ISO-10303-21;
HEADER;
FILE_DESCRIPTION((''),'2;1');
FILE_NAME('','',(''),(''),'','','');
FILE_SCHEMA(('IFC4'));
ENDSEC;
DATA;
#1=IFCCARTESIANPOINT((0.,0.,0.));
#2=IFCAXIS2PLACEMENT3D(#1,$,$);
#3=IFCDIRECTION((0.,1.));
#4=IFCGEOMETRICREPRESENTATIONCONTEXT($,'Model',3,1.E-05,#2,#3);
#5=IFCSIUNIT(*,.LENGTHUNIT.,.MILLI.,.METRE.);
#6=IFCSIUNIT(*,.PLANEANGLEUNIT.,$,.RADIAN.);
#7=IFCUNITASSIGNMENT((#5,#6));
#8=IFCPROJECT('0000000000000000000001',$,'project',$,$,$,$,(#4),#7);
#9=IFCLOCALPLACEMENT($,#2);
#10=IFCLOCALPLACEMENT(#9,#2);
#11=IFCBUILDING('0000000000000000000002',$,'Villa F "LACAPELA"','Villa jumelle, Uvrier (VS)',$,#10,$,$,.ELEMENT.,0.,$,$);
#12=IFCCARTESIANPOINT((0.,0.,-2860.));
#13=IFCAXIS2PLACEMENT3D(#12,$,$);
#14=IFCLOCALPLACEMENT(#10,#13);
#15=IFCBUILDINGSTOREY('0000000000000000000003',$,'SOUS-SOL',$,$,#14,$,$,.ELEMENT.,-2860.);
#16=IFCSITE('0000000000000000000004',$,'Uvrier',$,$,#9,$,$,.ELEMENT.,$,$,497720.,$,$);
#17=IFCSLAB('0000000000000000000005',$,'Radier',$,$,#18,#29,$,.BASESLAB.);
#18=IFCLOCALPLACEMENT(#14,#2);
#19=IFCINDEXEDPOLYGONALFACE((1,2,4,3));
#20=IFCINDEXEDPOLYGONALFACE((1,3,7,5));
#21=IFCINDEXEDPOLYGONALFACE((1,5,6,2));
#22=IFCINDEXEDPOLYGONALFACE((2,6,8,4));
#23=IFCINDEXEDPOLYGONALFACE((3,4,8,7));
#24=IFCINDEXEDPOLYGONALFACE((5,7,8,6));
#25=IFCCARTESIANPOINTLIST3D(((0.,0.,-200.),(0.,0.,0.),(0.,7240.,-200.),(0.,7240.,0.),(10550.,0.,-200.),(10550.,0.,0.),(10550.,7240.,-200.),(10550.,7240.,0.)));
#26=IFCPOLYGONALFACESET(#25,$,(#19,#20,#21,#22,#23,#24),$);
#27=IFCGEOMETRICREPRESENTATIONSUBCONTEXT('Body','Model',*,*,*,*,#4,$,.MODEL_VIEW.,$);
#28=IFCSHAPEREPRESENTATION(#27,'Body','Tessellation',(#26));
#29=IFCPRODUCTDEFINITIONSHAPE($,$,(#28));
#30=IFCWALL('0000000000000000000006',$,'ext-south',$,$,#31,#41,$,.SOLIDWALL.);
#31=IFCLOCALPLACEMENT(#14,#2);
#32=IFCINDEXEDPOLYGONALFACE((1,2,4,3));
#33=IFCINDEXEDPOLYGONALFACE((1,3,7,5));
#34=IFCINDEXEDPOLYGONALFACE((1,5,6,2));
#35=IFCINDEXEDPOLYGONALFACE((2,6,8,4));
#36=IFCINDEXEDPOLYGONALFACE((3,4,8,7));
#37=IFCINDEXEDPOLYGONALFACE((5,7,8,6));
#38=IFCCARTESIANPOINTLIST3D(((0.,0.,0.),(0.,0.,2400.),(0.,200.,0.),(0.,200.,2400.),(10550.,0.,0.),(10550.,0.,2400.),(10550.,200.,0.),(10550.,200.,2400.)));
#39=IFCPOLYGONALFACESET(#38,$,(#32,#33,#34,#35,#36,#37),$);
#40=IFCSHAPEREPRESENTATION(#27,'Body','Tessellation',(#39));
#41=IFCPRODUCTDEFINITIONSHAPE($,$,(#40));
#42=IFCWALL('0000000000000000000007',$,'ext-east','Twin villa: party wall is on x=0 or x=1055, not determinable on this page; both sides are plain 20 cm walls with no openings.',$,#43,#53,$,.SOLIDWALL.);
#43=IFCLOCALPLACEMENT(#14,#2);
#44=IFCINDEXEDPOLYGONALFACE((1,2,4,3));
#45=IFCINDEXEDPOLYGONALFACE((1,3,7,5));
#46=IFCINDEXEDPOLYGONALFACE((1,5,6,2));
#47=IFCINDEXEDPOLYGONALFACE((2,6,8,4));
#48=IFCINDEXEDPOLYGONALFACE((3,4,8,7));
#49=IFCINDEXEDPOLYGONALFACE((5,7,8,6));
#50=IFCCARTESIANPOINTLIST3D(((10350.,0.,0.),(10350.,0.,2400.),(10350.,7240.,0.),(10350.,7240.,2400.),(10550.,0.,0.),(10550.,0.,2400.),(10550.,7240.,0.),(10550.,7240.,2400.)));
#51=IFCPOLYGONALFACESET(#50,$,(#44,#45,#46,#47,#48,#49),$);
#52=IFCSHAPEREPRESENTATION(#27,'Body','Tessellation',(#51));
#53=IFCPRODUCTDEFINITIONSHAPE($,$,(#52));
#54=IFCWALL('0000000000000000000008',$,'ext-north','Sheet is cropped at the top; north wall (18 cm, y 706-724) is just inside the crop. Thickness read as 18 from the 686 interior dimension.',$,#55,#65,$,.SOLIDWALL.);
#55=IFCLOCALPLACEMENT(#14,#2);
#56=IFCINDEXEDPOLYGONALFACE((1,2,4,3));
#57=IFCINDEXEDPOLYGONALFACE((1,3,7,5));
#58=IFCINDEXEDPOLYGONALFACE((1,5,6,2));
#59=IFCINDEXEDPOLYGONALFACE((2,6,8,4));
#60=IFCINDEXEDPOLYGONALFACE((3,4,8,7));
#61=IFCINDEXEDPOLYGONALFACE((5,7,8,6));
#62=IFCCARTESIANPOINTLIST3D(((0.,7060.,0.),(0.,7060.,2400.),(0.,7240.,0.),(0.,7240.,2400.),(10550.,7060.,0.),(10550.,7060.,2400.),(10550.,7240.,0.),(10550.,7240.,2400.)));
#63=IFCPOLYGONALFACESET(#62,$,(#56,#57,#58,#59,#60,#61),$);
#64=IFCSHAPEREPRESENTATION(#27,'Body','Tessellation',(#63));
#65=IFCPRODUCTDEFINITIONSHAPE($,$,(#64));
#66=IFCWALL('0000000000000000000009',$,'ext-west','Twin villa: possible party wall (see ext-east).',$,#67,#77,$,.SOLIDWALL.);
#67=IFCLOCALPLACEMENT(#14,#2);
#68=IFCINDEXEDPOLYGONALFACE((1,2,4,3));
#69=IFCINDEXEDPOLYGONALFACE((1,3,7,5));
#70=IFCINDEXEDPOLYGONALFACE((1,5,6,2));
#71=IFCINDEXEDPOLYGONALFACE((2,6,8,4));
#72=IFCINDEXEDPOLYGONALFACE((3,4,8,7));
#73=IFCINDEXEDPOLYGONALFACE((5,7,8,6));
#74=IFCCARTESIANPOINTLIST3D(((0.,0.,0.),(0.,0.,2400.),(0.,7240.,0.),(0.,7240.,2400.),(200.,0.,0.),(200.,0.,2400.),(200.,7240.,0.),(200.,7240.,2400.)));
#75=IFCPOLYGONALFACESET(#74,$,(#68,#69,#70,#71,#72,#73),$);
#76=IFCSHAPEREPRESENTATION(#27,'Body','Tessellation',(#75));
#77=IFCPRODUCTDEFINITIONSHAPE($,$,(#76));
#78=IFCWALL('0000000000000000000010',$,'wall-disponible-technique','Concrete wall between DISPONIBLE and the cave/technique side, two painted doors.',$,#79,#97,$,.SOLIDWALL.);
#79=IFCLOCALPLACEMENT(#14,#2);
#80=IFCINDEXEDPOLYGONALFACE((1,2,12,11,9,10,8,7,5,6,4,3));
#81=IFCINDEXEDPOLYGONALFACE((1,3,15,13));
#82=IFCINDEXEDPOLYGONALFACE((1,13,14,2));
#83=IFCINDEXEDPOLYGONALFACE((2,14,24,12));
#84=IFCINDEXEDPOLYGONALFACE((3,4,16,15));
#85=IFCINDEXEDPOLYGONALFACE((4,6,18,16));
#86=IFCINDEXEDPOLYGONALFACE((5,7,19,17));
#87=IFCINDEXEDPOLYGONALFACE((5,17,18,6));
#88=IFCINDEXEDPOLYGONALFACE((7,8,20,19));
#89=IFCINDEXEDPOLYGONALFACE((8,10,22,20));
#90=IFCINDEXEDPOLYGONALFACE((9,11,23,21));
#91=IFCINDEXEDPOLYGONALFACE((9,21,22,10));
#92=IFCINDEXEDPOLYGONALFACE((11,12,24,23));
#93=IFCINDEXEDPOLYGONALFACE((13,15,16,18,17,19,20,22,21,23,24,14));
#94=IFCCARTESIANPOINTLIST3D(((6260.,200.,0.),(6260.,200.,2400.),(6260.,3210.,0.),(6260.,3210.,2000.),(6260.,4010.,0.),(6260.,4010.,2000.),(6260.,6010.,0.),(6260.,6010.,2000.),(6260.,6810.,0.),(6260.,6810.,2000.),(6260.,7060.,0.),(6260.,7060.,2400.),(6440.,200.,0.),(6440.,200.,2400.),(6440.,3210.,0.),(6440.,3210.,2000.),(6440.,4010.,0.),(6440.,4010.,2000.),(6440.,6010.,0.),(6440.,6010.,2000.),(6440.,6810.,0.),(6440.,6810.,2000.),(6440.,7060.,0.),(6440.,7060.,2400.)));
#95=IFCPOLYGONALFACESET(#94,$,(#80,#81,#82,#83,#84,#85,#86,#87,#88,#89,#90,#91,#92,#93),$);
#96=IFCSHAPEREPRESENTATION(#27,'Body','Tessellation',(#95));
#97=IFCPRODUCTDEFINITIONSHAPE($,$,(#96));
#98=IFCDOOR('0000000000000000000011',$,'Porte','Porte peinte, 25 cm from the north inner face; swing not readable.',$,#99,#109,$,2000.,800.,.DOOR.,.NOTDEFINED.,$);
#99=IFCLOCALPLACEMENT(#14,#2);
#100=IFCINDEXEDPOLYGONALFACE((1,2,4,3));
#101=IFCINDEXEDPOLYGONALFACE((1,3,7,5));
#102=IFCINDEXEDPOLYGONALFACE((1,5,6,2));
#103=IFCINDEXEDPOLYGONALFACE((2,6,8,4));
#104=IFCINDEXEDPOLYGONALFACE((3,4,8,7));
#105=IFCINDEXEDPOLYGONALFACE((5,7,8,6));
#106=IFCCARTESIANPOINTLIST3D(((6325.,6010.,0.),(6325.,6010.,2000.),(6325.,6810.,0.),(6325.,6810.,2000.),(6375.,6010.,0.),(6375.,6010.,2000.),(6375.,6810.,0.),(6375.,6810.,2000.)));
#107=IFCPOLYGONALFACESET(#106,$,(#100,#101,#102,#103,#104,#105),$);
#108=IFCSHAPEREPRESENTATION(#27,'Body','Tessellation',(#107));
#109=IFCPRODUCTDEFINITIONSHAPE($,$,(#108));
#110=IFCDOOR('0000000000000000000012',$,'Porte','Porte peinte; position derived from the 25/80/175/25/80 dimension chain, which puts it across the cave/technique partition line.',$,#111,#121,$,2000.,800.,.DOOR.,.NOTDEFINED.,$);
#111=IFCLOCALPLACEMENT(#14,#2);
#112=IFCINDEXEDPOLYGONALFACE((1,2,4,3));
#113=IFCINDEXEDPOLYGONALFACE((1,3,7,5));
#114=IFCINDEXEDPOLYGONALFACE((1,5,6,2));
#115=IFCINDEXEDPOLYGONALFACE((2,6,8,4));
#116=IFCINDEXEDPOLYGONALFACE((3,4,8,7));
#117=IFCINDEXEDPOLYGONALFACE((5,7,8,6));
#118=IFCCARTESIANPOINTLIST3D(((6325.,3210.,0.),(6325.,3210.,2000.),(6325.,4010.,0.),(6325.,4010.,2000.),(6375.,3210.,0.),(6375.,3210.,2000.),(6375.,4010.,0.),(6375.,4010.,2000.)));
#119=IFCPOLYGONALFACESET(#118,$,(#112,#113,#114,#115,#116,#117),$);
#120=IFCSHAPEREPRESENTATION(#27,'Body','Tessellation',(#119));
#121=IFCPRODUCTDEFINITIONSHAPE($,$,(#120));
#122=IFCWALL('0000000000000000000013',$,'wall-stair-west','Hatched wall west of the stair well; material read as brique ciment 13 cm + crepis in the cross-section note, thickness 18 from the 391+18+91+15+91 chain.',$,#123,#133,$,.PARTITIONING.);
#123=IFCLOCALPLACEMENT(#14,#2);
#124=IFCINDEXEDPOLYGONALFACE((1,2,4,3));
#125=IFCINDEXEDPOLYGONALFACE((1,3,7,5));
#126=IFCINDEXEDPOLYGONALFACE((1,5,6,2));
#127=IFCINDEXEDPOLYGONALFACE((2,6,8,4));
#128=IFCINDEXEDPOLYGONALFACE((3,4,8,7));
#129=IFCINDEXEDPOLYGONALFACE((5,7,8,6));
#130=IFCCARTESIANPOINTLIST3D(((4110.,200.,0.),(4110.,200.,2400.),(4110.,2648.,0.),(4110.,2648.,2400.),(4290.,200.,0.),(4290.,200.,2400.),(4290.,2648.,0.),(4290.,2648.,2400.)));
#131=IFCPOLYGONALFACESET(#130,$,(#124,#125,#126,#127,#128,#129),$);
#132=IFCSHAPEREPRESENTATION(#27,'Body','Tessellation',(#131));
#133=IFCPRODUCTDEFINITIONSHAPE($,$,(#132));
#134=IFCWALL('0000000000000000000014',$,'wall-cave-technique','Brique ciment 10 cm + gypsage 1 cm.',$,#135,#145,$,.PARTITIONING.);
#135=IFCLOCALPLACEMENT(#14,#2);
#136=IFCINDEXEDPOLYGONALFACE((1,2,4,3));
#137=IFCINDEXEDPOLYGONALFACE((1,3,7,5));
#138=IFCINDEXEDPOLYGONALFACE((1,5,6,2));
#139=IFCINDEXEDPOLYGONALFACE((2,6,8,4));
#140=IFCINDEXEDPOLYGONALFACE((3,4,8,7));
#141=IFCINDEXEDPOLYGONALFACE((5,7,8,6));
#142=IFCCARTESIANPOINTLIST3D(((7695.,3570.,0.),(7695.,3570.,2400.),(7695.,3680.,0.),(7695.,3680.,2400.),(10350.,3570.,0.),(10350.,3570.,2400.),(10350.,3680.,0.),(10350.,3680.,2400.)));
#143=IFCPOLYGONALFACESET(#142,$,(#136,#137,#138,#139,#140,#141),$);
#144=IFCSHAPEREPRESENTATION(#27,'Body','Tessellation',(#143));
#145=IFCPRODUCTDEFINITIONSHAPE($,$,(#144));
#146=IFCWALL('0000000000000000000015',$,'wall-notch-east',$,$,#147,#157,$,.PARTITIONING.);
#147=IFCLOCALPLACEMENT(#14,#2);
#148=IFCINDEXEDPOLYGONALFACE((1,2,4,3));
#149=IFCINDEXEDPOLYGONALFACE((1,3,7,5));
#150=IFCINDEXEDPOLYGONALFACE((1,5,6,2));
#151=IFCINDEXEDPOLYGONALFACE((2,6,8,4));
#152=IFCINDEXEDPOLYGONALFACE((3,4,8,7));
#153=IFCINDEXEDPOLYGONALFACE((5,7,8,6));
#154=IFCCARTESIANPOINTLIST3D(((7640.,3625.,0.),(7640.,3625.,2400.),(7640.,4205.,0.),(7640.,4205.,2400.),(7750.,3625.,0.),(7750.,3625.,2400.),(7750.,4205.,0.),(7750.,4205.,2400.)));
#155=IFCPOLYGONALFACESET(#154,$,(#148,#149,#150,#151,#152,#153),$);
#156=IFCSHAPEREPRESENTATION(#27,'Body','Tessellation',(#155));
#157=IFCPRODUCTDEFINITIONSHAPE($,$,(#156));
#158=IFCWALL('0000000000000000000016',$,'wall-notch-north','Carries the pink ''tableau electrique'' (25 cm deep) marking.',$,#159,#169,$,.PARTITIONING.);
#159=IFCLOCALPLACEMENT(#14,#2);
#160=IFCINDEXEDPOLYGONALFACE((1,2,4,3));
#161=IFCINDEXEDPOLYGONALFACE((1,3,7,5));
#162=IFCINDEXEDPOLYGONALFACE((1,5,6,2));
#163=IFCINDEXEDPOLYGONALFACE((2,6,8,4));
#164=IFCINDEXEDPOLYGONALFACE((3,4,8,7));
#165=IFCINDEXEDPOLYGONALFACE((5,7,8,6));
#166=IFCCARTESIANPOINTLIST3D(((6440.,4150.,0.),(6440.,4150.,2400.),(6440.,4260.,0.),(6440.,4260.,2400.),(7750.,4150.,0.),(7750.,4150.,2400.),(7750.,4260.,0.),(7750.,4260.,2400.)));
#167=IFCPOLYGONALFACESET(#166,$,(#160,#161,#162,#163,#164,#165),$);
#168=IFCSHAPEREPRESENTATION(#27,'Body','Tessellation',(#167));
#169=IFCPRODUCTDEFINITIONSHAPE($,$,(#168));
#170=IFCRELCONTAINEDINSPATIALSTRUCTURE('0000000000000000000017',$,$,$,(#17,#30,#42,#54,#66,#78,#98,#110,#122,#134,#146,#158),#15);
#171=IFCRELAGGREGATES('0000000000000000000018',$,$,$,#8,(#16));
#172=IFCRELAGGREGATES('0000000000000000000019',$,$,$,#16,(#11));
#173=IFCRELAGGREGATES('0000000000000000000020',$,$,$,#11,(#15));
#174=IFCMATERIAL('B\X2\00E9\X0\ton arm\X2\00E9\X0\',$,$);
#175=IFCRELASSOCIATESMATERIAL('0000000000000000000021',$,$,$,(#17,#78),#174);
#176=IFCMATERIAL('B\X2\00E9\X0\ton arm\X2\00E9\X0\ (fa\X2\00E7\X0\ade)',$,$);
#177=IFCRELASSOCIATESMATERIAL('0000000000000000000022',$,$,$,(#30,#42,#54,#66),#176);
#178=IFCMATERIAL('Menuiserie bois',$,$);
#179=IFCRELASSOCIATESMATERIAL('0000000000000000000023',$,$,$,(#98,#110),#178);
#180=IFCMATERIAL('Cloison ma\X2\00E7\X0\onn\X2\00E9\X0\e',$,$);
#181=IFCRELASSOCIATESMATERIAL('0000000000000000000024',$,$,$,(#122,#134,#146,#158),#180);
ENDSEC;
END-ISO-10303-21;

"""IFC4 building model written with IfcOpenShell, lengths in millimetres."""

from ifc_helpers import new_model, si_unit, direction, frame, frame_2d, origin, place, context, subcontext, project, spatial, polyline, rectangle, outline, extrude, material, element, fill, save


model = new_model("IFC4")

# Units and contexts
model_context = context("Model", 3, precision=1e-05, world=origin(), true_north=direction((0.0, 1.0)))
body_context = subcontext(model_context, "Body", "Model", "MODEL_VIEW")
ifc_project = project(units=[si_unit("LENGTHUNIT", "METRE", prefix="MILLI"), si_unit("PLANEANGLEUNIT", "RADIAN")], contexts=[model_context])

# Site, building, storey
site_placement = place(None, origin())
site = spatial("IfcSite", under=ifc_project, at=site_placement, Name="Uvrier", CompositionType="ELEMENT", RefElevation=497720.0)
building_placement = place(site_placement, origin())
building = spatial("IfcBuilding", under=site, at=building_placement, Name="Villa F \"LACAPELA\"", Description="Villa jumelle, Uvrier (VS)", CompositionType="ELEMENT", ElevationOfRefHeight=0.0)
storey_placement = place(building_placement, frame((0.0, 0.0, -2860.0)))
storey = spatial("IfcBuildingStorey", under=building, at=storey_placement, Name="SOUS-SOL", CompositionType="ELEMENT", Elevation=-2860.0)

# Slab
ifc_material_1 = material(Name="Béton armé")
slab_placement = place(storey_placement, origin())
element("IfcSlab", 1, at=slab_placement, inside=storey, material=ifc_material_1, Name="Radier", PredefinedType="BASESLAB", context=body_context, shape_type="SweptSolid", body=[
    extrude(outline(polyline([(0.0, 0.0), (10550.0, 0.0), (10550.0, 7240.0), (0.0, 7240.0), (0.0, 0.0)])), frame((0.0, 0.0, -200.0)), (0.0, 0.0, 1.0), 200.0),
])

# Walls
ifc_material_2 = material(Name="Béton armé (façade)")
wall_1_placement = place(storey_placement, frame((0.0, 100.0, 0.0), z_axis=(0.0, 0.0, 1.0), x_axis=(1.0, 0.0, 0.0)))
element("IfcWall", 2, at=wall_1_placement, inside=storey, material=ifc_material_2, Name="ext-south", PredefinedType="SOLIDWALL", context=body_context, shape_type="SweptSolid", body=[
    extrude(rectangle(XDim=10550.0, YDim=200.0, at=frame_2d((5275.0, 0.0))), origin(), (0.0, 0.0, 1.0), 2400.0),
])
wall_2_placement = place(storey_placement, frame((10450.0, 0.0, 0.0), z_axis=(0.0, 0.0, 1.0), x_axis=(0.0, 1.0, 0.0)))
element("IfcWall", 3, at=wall_2_placement, inside=storey, material=ifc_material_2, Name="ext-east", Description="Twin villa: party wall is on x=0 or x=1055, not determinable on this page; both sides are plain 20 cm walls with no openings.", PredefinedType="SOLIDWALL", context=body_context, shape_type="SweptSolid", body=[
    extrude(rectangle(XDim=7240.0, YDim=200.0, at=frame_2d((3620.0, 0.0))), origin(), (0.0, 0.0, 1.0), 2400.0),
])
wall_3_placement = place(storey_placement, frame((10550.0, 7150.0, 0.0), z_axis=(0.0, 0.0, 1.0), x_axis=(-1.0, 0.0, 0.0)))
element("IfcWall", 4, at=wall_3_placement, inside=storey, material=ifc_material_2, Name="ext-north", Description="Sheet is cropped at the top; north wall (18 cm, y 706-724) is just inside the crop. Thickness read as 18 from the 686 interior dimension.", PredefinedType="SOLIDWALL", context=body_context, shape_type="SweptSolid", body=[
    extrude(rectangle(XDim=10550.0, YDim=180.0, at=frame_2d((5275.0, 0.0))), origin(), (0.0, 0.0, 1.0), 2400.0),
])
wall_4_placement = place(storey_placement, frame((100.0, 7240.0, 0.0), z_axis=(0.0, 0.0, 1.0), x_axis=(0.0, -1.0, 0.0)))
element("IfcWall", 5, at=wall_4_placement, inside=storey, material=ifc_material_2, Name="ext-west", Description="Twin villa: possible party wall (see ext-east).", PredefinedType="SOLIDWALL", context=body_context, shape_type="SweptSolid", body=[
    extrude(rectangle(XDim=7240.0, YDim=200.0, at=frame_2d((3620.0, 0.0))), origin(), (0.0, 0.0, 1.0), 2400.0),
])

# Wall, openings, doors
wall_5_placement = place(storey_placement, frame((6350.0, 200.0, 0.0), z_axis=(0.0, 0.0, 1.0), x_axis=(0.0, 1.0, 0.0)))
wall_5 = element("IfcWall", 6, at=wall_5_placement, inside=storey, material=ifc_material_1, Name="wall-disponible-technique", Description="Concrete wall between DISPONIBLE and the cave/technique side, two painted doors.", PredefinedType="SOLIDWALL", context=body_context, shape_type="SweptSolid", body=[
    extrude(rectangle(XDim=6860.0, YDim=180.0, at=frame_2d((3430.0, 0.0))), origin(), (0.0, 0.0, 1.0), 2400.0),
])
opening_1_placement = place(wall_5_placement, frame((5810.0, 0.0, 0.0)))
opening_1 = element("IfcOpeningElement", 7, at=opening_1_placement, cuts=wall_5, PredefinedType="OPENING", context=body_context, shape_type="SweptSolid", body=[
    extrude(rectangle(XDim=800.0, YDim=380.0, at=frame_2d((400.0, 0.0))), origin(), (0.0, 0.0, 1.0), 2000.0),
])
opening_2_placement = place(wall_5_placement, frame((3010.0, 0.0, 0.0)))
opening_2 = element("IfcOpeningElement", 8, at=opening_2_placement, cuts=wall_5, PredefinedType="OPENING", context=body_context, shape_type="SweptSolid", body=[
    extrude(rectangle(XDim=800.0, YDim=380.0, at=frame_2d((400.0, 0.0))), origin(), (0.0, 0.0, 1.0), 2000.0),
])
ifc_material_3 = material(Name="Menuiserie bois")
door_1_placement = place(opening_1_placement, origin())
door_1 = element("IfcDoor", 9, at=door_1_placement, inside=storey, material=ifc_material_3, Name="Porte", Description="Porte peinte, 25 cm from the north inner face; swing not readable.", OperationType="NOTDEFINED", OverallHeight=2000.0, OverallWidth=800.0, PredefinedType="DOOR", context=body_context, shape_type="SweptSolid", body=[
    extrude(rectangle(XDim=800.0, YDim=50.0, at=frame_2d((400.0, 0.0))), origin(), (0.0, 0.0, 1.0), 2000.0),
])
fill(opening_1, door_1)
door_2_placement = place(opening_2_placement, origin())
door_2 = element("IfcDoor", 10, at=door_2_placement, inside=storey, material=ifc_material_3, Name="Porte", Description="Porte peinte; position derived from the 25/80/175/25/80 dimension chain, which puts it across the cave/technique partition line.", OperationType="NOTDEFINED", OverallHeight=2000.0, OverallWidth=800.0, PredefinedType="DOOR", context=body_context, shape_type="SweptSolid", body=[
    extrude(rectangle(XDim=800.0, YDim=50.0, at=frame_2d((400.0, 0.0))), origin(), (0.0, 0.0, 1.0), 2000.0),
])
fill(opening_2, door_2)

# Walls
ifc_material_4 = material(Name="Cloison maçonnée")
wall_6_placement = place(storey_placement, frame((4200.0, 200.0, 0.0), z_axis=(0.0, 0.0, 1.0), x_axis=(0.0, 1.0, 0.0)))
element("IfcWall", 11, at=wall_6_placement, inside=storey, material=ifc_material_4, Name="wall-stair-west", Description="Hatched wall west of the stair well; material read as brique ciment 13 cm + crepis in the cross-section note, thickness 18 from the 391+18+91+15+91 chain.", PredefinedType="PARTITIONING", context=body_context, shape_type="SweptSolid", body=[
    extrude(rectangle(XDim=2448.0, YDim=180.0, at=frame_2d((1224.0, 0.0))), origin(), (0.0, 0.0, 1.0), 2400.0),
])
wall_7_placement = place(storey_placement, frame((7695.0, 3625.0, 0.0), z_axis=(0.0, 0.0, 1.0), x_axis=(1.0, 0.0, 0.0)))
element("IfcWall", 12, at=wall_7_placement, inside=storey, material=ifc_material_4, Name="wall-cave-technique", Description="Brique ciment 10 cm + gypsage 1 cm.", PredefinedType="PARTITIONING", context=body_context, shape_type="SweptSolid", body=[
    extrude(rectangle(XDim=2655.0, YDim=110.0, at=frame_2d((1327.5, 0.0))), origin(), (0.0, 0.0, 1.0), 2400.0),
])
wall_8_placement = place(storey_placement, frame((7695.0, 3625.0, 0.0), z_axis=(0.0, 0.0, 1.0), x_axis=(0.0, 1.0, 0.0)))
element("IfcWall", 13, at=wall_8_placement, inside=storey, material=ifc_material_4, Name="wall-notch-east", PredefinedType="PARTITIONING", context=body_context, shape_type="SweptSolid", body=[
    extrude(rectangle(XDim=580.0, YDim=110.0, at=frame_2d((290.0, 0.0))), origin(), (0.0, 0.0, 1.0), 2400.0),
])
wall_9_placement = place(storey_placement, frame((6440.0, 4205.0, 0.0), z_axis=(0.0, 0.0, 1.0), x_axis=(1.0, 0.0, 0.0)))
element("IfcWall", 14, at=wall_9_placement, inside=storey, material=ifc_material_4, Name="wall-notch-north", Description="Carries the pink 'tableau electrique' (25 cm deep) marking.", PredefinedType="PARTITIONING", context=body_context, shape_type="SweptSolid", body=[
    extrude(rectangle(XDim=1310.0, YDim=110.0, at=frame_2d((655.0, 0.0))), origin(), (0.0, 0.0, 1.0), 2400.0),
])

save(model, "model.ifc")
